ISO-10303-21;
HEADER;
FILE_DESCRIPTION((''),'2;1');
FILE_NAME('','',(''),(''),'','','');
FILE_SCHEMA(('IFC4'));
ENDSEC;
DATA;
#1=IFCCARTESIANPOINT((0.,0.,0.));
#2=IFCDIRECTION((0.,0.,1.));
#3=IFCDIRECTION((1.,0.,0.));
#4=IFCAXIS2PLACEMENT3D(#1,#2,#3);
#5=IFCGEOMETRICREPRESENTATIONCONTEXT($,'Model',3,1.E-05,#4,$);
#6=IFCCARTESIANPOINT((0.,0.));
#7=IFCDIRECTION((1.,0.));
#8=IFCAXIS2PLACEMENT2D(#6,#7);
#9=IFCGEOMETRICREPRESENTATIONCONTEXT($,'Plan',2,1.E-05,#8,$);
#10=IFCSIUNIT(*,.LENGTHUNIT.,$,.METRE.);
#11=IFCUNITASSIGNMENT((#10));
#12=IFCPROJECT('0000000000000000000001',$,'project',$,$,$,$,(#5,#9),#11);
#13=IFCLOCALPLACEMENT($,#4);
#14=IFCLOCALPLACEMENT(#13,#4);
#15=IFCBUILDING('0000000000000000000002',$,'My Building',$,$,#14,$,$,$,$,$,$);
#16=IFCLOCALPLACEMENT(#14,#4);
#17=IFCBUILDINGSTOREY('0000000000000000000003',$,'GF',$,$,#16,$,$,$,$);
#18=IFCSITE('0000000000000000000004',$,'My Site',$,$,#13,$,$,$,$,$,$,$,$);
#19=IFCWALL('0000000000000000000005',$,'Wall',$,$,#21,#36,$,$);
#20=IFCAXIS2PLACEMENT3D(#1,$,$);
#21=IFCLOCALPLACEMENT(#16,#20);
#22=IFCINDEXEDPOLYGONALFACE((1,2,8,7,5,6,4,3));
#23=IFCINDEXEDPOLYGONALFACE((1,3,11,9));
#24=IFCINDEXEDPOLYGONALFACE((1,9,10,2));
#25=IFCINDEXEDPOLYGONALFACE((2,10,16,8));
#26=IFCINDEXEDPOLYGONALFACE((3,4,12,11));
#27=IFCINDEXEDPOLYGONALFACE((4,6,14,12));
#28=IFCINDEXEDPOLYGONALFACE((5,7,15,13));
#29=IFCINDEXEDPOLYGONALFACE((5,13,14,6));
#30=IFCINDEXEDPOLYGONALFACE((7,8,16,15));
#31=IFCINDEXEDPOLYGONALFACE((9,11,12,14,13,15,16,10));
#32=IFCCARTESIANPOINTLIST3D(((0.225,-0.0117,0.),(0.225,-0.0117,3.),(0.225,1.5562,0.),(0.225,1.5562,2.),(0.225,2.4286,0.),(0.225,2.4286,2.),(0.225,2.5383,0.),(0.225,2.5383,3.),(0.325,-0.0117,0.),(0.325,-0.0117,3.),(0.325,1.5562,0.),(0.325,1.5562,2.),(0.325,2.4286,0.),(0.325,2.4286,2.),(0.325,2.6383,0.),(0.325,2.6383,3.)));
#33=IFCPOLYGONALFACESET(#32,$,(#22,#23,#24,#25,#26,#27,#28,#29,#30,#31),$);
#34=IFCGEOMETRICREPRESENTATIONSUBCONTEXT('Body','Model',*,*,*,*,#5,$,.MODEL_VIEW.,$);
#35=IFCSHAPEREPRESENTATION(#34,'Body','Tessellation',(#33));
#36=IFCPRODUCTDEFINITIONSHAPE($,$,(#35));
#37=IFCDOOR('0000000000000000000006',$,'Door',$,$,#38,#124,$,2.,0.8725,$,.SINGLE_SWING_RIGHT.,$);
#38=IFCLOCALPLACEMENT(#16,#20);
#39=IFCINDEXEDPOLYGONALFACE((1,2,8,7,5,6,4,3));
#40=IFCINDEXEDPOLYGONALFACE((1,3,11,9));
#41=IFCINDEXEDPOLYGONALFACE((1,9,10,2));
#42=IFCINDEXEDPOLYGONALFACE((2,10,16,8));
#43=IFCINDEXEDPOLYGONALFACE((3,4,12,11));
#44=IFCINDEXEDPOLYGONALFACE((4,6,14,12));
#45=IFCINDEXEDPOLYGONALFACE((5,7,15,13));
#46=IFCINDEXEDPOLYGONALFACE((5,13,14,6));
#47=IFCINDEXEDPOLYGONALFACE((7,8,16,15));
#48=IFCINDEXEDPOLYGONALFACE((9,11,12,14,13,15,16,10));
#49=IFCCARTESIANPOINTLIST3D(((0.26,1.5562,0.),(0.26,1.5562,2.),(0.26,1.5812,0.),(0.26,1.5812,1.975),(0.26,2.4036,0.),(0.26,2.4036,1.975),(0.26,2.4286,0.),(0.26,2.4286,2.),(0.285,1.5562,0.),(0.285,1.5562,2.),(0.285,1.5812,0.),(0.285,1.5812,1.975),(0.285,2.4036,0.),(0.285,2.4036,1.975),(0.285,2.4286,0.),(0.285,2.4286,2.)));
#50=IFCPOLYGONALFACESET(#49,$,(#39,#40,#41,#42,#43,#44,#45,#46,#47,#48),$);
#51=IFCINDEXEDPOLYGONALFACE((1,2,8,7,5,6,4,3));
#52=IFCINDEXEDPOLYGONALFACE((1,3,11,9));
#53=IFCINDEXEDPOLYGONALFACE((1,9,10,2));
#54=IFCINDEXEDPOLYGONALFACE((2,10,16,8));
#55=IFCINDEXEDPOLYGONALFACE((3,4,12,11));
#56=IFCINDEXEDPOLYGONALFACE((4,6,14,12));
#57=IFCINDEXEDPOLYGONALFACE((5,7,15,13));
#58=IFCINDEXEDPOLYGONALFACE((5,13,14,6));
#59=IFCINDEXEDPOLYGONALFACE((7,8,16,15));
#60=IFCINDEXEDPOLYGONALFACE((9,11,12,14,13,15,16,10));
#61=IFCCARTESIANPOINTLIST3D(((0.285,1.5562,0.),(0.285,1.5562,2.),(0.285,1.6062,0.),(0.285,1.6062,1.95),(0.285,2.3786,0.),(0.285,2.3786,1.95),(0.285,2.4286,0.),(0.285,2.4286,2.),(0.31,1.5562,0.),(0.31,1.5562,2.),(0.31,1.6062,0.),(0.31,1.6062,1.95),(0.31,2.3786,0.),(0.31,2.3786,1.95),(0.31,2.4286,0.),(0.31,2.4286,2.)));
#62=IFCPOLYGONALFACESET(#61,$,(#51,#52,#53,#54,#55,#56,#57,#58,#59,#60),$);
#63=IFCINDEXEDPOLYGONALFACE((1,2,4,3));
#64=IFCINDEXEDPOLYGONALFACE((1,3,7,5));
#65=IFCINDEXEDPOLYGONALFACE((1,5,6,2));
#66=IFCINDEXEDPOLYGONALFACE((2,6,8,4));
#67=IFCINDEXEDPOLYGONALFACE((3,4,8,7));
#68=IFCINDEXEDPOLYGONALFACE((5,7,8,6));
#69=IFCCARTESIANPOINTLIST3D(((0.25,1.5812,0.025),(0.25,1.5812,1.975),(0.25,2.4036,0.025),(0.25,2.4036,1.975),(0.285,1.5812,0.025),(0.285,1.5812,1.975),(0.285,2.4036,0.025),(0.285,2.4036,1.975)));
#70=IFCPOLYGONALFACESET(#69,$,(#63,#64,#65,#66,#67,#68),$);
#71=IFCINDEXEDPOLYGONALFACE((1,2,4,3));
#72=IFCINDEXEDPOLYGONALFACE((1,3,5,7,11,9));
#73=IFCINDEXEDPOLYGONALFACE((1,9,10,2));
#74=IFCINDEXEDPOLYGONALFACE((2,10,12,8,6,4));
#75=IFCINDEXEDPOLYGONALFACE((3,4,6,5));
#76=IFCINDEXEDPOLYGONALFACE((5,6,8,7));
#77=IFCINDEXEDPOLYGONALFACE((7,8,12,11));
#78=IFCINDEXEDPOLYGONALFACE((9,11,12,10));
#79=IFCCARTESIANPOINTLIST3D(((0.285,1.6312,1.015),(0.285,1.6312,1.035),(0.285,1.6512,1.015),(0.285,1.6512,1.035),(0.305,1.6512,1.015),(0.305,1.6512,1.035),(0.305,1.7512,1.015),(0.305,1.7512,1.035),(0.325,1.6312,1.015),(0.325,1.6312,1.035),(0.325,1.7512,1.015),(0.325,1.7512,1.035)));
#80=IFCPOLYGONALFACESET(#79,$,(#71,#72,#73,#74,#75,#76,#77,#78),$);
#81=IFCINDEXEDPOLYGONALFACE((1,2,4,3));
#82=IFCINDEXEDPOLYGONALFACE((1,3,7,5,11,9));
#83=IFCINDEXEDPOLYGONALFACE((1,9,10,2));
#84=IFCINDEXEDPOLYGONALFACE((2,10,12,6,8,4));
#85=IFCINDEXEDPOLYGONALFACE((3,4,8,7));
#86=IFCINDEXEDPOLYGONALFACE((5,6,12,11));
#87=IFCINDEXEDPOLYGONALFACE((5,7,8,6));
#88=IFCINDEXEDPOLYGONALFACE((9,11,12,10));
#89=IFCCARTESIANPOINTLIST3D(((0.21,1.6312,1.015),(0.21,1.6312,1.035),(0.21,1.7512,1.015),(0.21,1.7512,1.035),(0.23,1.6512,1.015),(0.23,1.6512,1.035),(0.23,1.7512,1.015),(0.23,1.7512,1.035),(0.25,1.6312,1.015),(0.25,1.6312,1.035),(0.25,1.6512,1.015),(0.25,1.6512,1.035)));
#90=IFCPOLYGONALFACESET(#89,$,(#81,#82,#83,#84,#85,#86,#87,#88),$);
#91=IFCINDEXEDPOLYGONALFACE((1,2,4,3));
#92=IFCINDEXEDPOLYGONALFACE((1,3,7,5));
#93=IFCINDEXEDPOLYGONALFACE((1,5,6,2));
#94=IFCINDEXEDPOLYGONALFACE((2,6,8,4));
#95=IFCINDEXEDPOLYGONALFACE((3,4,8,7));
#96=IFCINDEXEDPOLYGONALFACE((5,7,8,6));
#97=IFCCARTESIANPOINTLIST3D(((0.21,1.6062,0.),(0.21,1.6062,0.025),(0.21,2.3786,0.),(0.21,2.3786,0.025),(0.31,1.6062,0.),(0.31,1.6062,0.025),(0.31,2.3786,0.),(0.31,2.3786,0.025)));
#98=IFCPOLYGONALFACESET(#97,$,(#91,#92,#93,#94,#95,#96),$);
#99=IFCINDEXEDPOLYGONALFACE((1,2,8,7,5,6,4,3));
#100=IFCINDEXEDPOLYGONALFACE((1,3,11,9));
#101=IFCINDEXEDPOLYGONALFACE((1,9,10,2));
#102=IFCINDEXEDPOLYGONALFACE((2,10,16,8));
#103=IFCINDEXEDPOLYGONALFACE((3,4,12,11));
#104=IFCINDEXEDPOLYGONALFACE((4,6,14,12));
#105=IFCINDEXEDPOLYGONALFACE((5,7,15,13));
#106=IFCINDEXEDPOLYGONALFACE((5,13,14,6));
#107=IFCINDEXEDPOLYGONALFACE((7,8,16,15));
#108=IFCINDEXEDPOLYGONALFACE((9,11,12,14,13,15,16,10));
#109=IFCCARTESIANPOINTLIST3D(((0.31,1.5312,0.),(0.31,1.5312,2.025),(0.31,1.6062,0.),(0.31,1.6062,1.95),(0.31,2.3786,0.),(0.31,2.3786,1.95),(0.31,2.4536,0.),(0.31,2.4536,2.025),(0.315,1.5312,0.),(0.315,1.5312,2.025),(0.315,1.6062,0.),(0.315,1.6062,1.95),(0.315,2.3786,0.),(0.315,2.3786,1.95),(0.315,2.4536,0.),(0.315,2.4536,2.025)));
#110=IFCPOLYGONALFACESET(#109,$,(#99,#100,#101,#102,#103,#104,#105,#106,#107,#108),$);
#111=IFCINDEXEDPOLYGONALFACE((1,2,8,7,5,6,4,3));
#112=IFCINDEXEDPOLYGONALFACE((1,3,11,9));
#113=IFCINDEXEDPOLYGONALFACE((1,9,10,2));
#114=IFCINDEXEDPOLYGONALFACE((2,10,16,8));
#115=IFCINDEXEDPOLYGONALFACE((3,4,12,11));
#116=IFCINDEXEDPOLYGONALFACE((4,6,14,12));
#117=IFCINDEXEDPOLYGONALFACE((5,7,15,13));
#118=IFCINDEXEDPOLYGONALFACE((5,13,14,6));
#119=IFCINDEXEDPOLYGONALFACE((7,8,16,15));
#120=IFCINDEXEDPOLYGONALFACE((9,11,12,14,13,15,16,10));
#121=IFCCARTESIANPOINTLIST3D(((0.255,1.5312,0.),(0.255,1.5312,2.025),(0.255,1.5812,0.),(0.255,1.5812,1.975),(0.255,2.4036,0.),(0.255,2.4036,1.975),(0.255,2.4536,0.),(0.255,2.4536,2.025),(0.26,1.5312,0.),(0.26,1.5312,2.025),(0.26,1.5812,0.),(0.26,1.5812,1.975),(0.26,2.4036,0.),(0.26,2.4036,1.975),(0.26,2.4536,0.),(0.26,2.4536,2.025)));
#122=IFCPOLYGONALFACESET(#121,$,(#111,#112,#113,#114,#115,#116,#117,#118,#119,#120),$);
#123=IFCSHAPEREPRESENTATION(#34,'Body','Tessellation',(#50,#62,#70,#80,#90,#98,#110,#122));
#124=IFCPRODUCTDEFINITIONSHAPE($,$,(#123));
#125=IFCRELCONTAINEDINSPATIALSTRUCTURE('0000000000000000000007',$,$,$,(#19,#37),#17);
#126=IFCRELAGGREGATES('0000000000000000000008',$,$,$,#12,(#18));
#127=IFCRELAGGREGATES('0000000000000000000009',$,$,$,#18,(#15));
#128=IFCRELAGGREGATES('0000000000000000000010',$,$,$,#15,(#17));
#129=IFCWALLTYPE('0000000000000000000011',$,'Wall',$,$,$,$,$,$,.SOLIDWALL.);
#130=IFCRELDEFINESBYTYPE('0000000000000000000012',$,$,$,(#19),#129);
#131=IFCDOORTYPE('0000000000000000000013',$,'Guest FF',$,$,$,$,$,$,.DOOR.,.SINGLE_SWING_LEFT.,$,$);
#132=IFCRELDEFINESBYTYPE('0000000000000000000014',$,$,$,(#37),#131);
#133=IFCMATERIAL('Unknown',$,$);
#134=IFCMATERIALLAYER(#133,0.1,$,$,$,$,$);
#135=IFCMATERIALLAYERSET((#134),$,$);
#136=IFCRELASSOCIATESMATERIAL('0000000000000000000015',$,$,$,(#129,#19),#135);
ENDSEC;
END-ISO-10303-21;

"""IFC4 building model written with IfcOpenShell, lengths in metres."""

from ifc_helpers import new_model, entity, si_unit, frame, origin_with_axes, origin_2d_with_axis, place, context, subcontext, project, spatial, line, indexed_curve, outline, extrude, shape, source, transform, mapped, material, layer, layer_set, layer_usage, type_object, type_shapes, element, fill, save


model = new_model("IFC4")

# Units and contexts
model_context = context("Model", 3, precision=1e-05, world=origin_with_axes())
plan_context = context("Plan", 2, precision=1e-05, world=origin_2d_with_axis())
body_context_1 = subcontext(model_context, "Body", "Model", "MODEL_VIEW")
body_context_2 = subcontext(plan_context, "Body", "Plan", "PLAN_VIEW")
ifc_project = project(units=[si_unit("LENGTHUNIT", "METRE")], contexts=[model_context, plan_context])

# Site, building, storey
site_placement = place(None, origin_with_axes())
site = spatial("IfcSite", under=ifc_project, at=site_placement, Name="My Site")
building_placement = place(site_placement, origin_with_axes())
building = spatial("IfcBuilding", under=site, at=building_placement, Name="My Building")
storey_placement = place(building_placement, origin_with_axes())
storey = spatial("IfcBuildingStorey", under=building, at=storey_placement, Name="GF")

# Shared definitions
ifc_material = material(Name="Unknown")

# Shared definitions
ifc_layer_1 = layer(ifc_material, 0.1)
ifc_layer_set_1 = layer_set([ifc_layer_1])
wall_type = type_object("IfcWallType", Name="Wall", PredefinedType="SOLIDWALL", material=ifc_layer_set_1)

# Wall, opening, door
ifc_layer_usage_1 = layer_usage(ifc_layer_set_1, "AXIS2", "POSITIVE", 0.0)
wall_1_placement = place(storey_placement, frame((0.325, -0.0117, 0.0), z_axis=(0.0, 0.0, 1.0), x_axis=(0.0, 1.0, 0.0)))
wall_1 = element("IfcWall", 1, at=wall_1_placement, inside=storey, type_object=wall_type, material=ifc_layer_usage_1, Name="Wall", context=body_context_1, shape_type="SweptSolid", body=[
    extrude(outline(indexed_curve([(0.0, 0.0), (0.0, 0.1), (2.55, 0.1), (2.65, 0.0)], segments=[line(1, 2, 3, 4, 1)])), origin_with_axes(), (0.0, 0.0, 1.0), 3.0),
])
shared_shape_1 = source(origin_with_axes(), body_context_1, "Body", "SweptSolid", [
    extrude(outline(indexed_curve([(0.0, 0.0), (0.8725, 0.0), (0.8725, 2.0), (0.0, 2.0)], segments=[line(1, 2, 3, 4, 1)])), frame((0.0, -0.6, 0.0), z_axis=(0.0, -1.0, 0.0), x_axis=(1.0, 0.0, 0.0)), (0.0, 0.0, -1.0), 1.2),
])
opening_1_placement = place(wall_1_placement, frame((1.5679, 0.015, 0.0), z_axis=(0.0, 0.0, 1.0), x_axis=(1.0, 0.0, 0.0)))
opening_1 = element("IfcOpeningElement", 2, at=opening_1_placement, cuts=wall_1, PredefinedType="OPENING", context=body_context_1, shape_type="MappedRepresentation", body=[
    mapped(shared_shape_1, transform((0.0, 0.0, 0.0), x_axis=(1.0, 0.0, 0.0), y_axis=(0.0, 1.0, 0.0), z_axis=(0.0, 0.0, 1.0), scale=1.0)),
])
door_type_1 = type_object("IfcDoorType", Name="Guest FF", OperationType="SINGLE_SWING_LEFT", PredefinedType="DOOR")
shared_shape_2 = source(origin_with_axes(), body_context_1, "Body", "SweptSolid", [
    extrude(outline(indexed_curve([(0.0, 0.0), (0.0, 2.0), (0.8725, 2.0), (0.8725, 0.0), (0.8475, 0.0), (0.8475, 1.975), (0.025, 1.975), (0.025, 0.0)], segments=[line(1, 2, 3, 4, 5, 6, 7, 8, 1)])), frame((0.0, 0.025, 0.0), z_axis=(0.0, -1.0, 0.0), x_axis=(1.0, 0.0, 0.0)), (0.0, 0.0, -1.0), 0.025),
    extrude(outline(indexed_curve([(0.0, 0.0), (0.0, 2.0), (0.8725, 2.0), (0.8725, 0.0), (0.8225, 0.0), (0.8225, 1.95), (0.05, 1.95), (0.05, 0.0)], segments=[line(1, 2, 3, 4, 5, 6, 7, 8, 1)])), frame((0.0, 0.0, 0.0), z_axis=(0.0, -1.0, 0.0), x_axis=(1.0, 0.0, 0.0)), (0.0, 0.0, -1.0), 0.025),
    extrude(outline(indexed_curve([(0.0, 0.0), (0.8225, 0.0), (0.8225, 0.035), (0.0, 0.035)], segments=[line(1, 2, 3, 4, 1)])), frame((0.025, 0.025, 0.025), z_axis=(0.0, 0.0, 1.0), x_axis=(1.0, 0.0, 0.0)), (0.0, 0.0, 1.0), 1.95),
    extrude(outline(indexed_curve([(0.0, 0.0), (0.0, -0.04), (0.12, -0.04), (0.12, -0.02), (0.02, -0.02), (0.02, 0.0)], segments=[line(1, 2, 3, 4, 5, 6, 1)])), frame((0.075, 0.025, 1.015), z_axis=(0.0, 0.0, 1.0), x_axis=(1.0, 0.0, 0.0)), (0.0, 0.0, 1.0), 0.02),
    extrude(outline(indexed_curve([(0.0, 0.0), (0.0, 0.04), (0.12, 0.04), (0.12, 0.02), (0.02, 0.02), (0.02, 0.0)], segments=[line(1, 2, 3, 4, 5, 6, 1)])), frame((0.075, 0.06, 1.015), z_axis=(0.0, 0.0, 1.0), x_axis=(1.0, 0.0, 0.0)), (0.0, 0.0, 1.0), 0.02),
    extrude(outline(indexed_curve([(0.0, 0.0), (0.7725, 0.0), (0.7725, 0.1), (0.0, 0.1)], segments=[line(1, 2, 3, 4, 1)])), frame((0.05, 0.0, 0.0), z_axis=(0.0, 0.0, 1.0), x_axis=(1.0, 0.0, 0.0)), (0.0, 0.0, 1.0), 0.025),
    extrude(outline(indexed_curve([(0.0, 0.0), (0.0, 2.025), (0.9225, 2.025), (0.9225, 0.0), (0.8475, 0.0), (0.8475, 1.95), (0.075, 1.95), (0.075, 0.0)], segments=[line(1, 2, 3, 4, 5, 6, 7, 8, 1)])), frame((-0.025, -0.005, 0.0), z_axis=(0.0, -1.0, 0.0), x_axis=(1.0, 0.0, 0.0)), (0.0, 0.0, -1.0), 0.005),
    extrude(outline(indexed_curve([(0.0, 0.0), (0.0, 2.025), (0.9225, 2.025), (0.9225, 0.0), (0.8725, 0.0), (0.8725, 1.975), (0.05, 1.975), (0.05, 0.0)], segments=[line(1, 2, 3, 4, 5, 6, 7, 8, 1)])), frame((-0.025, 0.05, 0.0), z_axis=(0.0, -1.0, 0.0), x_axis=(1.0, 0.0, 0.0)), (0.0, 0.0, -1.0), 0.005),
])
shared_shape_3 = source(origin_with_axes(), body_context_2, "Body", "Curve2D", [
    entity("IfcIndexedPolyCurve", entity("IfcCartesianPointList2D", [[0.0, 0.0], [0.0, 0.05], [0.025, 0.05], [0.025, 0.025], [0.05, 0.025], [0.05, 0.0]]), [entity("IfcLineIndex", [1, 2, 3, 4, 5, 6, 1])]),
    entity("IfcIndexedPolyCurve", entity("IfcCartesianPointList2D", [[0.8725, 0.0], [0.8725, 0.05], [0.8475, 0.05], [0.8475, 0.025], [0.8225, 0.025], [0.8225, 0.0]]), [entity("IfcLineIndex", [1, 2, 3, 4, 5, 6, 1])]),
    entity("IfcTrimmedCurve", entity("IfcEllipse", entity("IfcAxis2Placement2D", entity("IfcCartesianPoint", [0.8125, 0.05]), entity("IfcDirection", [1.0, 0.0])), 0.7875, 0.8225), [entity("IfcCartesianPoint", [0.8125, 0.8725])], [entity("IfcCartesianPoint", [0.025, 0.05])], True, "CARTESIAN"),
    entity("IfcIndexedPolyCurve", entity("IfcCartesianPointList2D", [[0.8475, 0.05], [0.8125, 0.05], [0.8125, 0.8725], [0.8475, 0.8725]]), [entity("IfcLineIndex", [1, 2, 3, 4, 1])]),
])
type_shapes(door_type_1, [shared_shape_2, shared_shape_3])
door_1_placement = place(opening_1_placement, frame((0.0, 0.0, 0.0), z_axis=(0.0, 0.0, 1.0), x_axis=(1.0, 0.0, 0.0)))
door_1 = element("IfcDoor", 3, at=door_1_placement, inside=storey, type_object=door_type_1, Name="Door", OperationType="SINGLE_SWING_RIGHT", OverallHeight=2.0, OverallWidth=0.8725, shapes=[
    shape(body_context_1, "Body", "MappedRepresentation", [mapped(shared_shape_2, transform((0.0, 0.0, 0.0), x_axis=(1.0, 0.0, 0.0), y_axis=(0.0, 1.0, 0.0), z_axis=(0.0, 0.0, 1.0), scale=1.0))]),
    shape(body_context_2, "Body", "MappedRepresentation", [mapped(shared_shape_3, transform((0.0, 0.0, 0.0), x_axis=(1.0, 0.0, 0.0), y_axis=(0.0, 1.0, 0.0), z_axis=(0.0, 0.0, 1.0), scale=1.0))]),
])
fill(opening_1, door_1)

save(model, "model.ifc")
